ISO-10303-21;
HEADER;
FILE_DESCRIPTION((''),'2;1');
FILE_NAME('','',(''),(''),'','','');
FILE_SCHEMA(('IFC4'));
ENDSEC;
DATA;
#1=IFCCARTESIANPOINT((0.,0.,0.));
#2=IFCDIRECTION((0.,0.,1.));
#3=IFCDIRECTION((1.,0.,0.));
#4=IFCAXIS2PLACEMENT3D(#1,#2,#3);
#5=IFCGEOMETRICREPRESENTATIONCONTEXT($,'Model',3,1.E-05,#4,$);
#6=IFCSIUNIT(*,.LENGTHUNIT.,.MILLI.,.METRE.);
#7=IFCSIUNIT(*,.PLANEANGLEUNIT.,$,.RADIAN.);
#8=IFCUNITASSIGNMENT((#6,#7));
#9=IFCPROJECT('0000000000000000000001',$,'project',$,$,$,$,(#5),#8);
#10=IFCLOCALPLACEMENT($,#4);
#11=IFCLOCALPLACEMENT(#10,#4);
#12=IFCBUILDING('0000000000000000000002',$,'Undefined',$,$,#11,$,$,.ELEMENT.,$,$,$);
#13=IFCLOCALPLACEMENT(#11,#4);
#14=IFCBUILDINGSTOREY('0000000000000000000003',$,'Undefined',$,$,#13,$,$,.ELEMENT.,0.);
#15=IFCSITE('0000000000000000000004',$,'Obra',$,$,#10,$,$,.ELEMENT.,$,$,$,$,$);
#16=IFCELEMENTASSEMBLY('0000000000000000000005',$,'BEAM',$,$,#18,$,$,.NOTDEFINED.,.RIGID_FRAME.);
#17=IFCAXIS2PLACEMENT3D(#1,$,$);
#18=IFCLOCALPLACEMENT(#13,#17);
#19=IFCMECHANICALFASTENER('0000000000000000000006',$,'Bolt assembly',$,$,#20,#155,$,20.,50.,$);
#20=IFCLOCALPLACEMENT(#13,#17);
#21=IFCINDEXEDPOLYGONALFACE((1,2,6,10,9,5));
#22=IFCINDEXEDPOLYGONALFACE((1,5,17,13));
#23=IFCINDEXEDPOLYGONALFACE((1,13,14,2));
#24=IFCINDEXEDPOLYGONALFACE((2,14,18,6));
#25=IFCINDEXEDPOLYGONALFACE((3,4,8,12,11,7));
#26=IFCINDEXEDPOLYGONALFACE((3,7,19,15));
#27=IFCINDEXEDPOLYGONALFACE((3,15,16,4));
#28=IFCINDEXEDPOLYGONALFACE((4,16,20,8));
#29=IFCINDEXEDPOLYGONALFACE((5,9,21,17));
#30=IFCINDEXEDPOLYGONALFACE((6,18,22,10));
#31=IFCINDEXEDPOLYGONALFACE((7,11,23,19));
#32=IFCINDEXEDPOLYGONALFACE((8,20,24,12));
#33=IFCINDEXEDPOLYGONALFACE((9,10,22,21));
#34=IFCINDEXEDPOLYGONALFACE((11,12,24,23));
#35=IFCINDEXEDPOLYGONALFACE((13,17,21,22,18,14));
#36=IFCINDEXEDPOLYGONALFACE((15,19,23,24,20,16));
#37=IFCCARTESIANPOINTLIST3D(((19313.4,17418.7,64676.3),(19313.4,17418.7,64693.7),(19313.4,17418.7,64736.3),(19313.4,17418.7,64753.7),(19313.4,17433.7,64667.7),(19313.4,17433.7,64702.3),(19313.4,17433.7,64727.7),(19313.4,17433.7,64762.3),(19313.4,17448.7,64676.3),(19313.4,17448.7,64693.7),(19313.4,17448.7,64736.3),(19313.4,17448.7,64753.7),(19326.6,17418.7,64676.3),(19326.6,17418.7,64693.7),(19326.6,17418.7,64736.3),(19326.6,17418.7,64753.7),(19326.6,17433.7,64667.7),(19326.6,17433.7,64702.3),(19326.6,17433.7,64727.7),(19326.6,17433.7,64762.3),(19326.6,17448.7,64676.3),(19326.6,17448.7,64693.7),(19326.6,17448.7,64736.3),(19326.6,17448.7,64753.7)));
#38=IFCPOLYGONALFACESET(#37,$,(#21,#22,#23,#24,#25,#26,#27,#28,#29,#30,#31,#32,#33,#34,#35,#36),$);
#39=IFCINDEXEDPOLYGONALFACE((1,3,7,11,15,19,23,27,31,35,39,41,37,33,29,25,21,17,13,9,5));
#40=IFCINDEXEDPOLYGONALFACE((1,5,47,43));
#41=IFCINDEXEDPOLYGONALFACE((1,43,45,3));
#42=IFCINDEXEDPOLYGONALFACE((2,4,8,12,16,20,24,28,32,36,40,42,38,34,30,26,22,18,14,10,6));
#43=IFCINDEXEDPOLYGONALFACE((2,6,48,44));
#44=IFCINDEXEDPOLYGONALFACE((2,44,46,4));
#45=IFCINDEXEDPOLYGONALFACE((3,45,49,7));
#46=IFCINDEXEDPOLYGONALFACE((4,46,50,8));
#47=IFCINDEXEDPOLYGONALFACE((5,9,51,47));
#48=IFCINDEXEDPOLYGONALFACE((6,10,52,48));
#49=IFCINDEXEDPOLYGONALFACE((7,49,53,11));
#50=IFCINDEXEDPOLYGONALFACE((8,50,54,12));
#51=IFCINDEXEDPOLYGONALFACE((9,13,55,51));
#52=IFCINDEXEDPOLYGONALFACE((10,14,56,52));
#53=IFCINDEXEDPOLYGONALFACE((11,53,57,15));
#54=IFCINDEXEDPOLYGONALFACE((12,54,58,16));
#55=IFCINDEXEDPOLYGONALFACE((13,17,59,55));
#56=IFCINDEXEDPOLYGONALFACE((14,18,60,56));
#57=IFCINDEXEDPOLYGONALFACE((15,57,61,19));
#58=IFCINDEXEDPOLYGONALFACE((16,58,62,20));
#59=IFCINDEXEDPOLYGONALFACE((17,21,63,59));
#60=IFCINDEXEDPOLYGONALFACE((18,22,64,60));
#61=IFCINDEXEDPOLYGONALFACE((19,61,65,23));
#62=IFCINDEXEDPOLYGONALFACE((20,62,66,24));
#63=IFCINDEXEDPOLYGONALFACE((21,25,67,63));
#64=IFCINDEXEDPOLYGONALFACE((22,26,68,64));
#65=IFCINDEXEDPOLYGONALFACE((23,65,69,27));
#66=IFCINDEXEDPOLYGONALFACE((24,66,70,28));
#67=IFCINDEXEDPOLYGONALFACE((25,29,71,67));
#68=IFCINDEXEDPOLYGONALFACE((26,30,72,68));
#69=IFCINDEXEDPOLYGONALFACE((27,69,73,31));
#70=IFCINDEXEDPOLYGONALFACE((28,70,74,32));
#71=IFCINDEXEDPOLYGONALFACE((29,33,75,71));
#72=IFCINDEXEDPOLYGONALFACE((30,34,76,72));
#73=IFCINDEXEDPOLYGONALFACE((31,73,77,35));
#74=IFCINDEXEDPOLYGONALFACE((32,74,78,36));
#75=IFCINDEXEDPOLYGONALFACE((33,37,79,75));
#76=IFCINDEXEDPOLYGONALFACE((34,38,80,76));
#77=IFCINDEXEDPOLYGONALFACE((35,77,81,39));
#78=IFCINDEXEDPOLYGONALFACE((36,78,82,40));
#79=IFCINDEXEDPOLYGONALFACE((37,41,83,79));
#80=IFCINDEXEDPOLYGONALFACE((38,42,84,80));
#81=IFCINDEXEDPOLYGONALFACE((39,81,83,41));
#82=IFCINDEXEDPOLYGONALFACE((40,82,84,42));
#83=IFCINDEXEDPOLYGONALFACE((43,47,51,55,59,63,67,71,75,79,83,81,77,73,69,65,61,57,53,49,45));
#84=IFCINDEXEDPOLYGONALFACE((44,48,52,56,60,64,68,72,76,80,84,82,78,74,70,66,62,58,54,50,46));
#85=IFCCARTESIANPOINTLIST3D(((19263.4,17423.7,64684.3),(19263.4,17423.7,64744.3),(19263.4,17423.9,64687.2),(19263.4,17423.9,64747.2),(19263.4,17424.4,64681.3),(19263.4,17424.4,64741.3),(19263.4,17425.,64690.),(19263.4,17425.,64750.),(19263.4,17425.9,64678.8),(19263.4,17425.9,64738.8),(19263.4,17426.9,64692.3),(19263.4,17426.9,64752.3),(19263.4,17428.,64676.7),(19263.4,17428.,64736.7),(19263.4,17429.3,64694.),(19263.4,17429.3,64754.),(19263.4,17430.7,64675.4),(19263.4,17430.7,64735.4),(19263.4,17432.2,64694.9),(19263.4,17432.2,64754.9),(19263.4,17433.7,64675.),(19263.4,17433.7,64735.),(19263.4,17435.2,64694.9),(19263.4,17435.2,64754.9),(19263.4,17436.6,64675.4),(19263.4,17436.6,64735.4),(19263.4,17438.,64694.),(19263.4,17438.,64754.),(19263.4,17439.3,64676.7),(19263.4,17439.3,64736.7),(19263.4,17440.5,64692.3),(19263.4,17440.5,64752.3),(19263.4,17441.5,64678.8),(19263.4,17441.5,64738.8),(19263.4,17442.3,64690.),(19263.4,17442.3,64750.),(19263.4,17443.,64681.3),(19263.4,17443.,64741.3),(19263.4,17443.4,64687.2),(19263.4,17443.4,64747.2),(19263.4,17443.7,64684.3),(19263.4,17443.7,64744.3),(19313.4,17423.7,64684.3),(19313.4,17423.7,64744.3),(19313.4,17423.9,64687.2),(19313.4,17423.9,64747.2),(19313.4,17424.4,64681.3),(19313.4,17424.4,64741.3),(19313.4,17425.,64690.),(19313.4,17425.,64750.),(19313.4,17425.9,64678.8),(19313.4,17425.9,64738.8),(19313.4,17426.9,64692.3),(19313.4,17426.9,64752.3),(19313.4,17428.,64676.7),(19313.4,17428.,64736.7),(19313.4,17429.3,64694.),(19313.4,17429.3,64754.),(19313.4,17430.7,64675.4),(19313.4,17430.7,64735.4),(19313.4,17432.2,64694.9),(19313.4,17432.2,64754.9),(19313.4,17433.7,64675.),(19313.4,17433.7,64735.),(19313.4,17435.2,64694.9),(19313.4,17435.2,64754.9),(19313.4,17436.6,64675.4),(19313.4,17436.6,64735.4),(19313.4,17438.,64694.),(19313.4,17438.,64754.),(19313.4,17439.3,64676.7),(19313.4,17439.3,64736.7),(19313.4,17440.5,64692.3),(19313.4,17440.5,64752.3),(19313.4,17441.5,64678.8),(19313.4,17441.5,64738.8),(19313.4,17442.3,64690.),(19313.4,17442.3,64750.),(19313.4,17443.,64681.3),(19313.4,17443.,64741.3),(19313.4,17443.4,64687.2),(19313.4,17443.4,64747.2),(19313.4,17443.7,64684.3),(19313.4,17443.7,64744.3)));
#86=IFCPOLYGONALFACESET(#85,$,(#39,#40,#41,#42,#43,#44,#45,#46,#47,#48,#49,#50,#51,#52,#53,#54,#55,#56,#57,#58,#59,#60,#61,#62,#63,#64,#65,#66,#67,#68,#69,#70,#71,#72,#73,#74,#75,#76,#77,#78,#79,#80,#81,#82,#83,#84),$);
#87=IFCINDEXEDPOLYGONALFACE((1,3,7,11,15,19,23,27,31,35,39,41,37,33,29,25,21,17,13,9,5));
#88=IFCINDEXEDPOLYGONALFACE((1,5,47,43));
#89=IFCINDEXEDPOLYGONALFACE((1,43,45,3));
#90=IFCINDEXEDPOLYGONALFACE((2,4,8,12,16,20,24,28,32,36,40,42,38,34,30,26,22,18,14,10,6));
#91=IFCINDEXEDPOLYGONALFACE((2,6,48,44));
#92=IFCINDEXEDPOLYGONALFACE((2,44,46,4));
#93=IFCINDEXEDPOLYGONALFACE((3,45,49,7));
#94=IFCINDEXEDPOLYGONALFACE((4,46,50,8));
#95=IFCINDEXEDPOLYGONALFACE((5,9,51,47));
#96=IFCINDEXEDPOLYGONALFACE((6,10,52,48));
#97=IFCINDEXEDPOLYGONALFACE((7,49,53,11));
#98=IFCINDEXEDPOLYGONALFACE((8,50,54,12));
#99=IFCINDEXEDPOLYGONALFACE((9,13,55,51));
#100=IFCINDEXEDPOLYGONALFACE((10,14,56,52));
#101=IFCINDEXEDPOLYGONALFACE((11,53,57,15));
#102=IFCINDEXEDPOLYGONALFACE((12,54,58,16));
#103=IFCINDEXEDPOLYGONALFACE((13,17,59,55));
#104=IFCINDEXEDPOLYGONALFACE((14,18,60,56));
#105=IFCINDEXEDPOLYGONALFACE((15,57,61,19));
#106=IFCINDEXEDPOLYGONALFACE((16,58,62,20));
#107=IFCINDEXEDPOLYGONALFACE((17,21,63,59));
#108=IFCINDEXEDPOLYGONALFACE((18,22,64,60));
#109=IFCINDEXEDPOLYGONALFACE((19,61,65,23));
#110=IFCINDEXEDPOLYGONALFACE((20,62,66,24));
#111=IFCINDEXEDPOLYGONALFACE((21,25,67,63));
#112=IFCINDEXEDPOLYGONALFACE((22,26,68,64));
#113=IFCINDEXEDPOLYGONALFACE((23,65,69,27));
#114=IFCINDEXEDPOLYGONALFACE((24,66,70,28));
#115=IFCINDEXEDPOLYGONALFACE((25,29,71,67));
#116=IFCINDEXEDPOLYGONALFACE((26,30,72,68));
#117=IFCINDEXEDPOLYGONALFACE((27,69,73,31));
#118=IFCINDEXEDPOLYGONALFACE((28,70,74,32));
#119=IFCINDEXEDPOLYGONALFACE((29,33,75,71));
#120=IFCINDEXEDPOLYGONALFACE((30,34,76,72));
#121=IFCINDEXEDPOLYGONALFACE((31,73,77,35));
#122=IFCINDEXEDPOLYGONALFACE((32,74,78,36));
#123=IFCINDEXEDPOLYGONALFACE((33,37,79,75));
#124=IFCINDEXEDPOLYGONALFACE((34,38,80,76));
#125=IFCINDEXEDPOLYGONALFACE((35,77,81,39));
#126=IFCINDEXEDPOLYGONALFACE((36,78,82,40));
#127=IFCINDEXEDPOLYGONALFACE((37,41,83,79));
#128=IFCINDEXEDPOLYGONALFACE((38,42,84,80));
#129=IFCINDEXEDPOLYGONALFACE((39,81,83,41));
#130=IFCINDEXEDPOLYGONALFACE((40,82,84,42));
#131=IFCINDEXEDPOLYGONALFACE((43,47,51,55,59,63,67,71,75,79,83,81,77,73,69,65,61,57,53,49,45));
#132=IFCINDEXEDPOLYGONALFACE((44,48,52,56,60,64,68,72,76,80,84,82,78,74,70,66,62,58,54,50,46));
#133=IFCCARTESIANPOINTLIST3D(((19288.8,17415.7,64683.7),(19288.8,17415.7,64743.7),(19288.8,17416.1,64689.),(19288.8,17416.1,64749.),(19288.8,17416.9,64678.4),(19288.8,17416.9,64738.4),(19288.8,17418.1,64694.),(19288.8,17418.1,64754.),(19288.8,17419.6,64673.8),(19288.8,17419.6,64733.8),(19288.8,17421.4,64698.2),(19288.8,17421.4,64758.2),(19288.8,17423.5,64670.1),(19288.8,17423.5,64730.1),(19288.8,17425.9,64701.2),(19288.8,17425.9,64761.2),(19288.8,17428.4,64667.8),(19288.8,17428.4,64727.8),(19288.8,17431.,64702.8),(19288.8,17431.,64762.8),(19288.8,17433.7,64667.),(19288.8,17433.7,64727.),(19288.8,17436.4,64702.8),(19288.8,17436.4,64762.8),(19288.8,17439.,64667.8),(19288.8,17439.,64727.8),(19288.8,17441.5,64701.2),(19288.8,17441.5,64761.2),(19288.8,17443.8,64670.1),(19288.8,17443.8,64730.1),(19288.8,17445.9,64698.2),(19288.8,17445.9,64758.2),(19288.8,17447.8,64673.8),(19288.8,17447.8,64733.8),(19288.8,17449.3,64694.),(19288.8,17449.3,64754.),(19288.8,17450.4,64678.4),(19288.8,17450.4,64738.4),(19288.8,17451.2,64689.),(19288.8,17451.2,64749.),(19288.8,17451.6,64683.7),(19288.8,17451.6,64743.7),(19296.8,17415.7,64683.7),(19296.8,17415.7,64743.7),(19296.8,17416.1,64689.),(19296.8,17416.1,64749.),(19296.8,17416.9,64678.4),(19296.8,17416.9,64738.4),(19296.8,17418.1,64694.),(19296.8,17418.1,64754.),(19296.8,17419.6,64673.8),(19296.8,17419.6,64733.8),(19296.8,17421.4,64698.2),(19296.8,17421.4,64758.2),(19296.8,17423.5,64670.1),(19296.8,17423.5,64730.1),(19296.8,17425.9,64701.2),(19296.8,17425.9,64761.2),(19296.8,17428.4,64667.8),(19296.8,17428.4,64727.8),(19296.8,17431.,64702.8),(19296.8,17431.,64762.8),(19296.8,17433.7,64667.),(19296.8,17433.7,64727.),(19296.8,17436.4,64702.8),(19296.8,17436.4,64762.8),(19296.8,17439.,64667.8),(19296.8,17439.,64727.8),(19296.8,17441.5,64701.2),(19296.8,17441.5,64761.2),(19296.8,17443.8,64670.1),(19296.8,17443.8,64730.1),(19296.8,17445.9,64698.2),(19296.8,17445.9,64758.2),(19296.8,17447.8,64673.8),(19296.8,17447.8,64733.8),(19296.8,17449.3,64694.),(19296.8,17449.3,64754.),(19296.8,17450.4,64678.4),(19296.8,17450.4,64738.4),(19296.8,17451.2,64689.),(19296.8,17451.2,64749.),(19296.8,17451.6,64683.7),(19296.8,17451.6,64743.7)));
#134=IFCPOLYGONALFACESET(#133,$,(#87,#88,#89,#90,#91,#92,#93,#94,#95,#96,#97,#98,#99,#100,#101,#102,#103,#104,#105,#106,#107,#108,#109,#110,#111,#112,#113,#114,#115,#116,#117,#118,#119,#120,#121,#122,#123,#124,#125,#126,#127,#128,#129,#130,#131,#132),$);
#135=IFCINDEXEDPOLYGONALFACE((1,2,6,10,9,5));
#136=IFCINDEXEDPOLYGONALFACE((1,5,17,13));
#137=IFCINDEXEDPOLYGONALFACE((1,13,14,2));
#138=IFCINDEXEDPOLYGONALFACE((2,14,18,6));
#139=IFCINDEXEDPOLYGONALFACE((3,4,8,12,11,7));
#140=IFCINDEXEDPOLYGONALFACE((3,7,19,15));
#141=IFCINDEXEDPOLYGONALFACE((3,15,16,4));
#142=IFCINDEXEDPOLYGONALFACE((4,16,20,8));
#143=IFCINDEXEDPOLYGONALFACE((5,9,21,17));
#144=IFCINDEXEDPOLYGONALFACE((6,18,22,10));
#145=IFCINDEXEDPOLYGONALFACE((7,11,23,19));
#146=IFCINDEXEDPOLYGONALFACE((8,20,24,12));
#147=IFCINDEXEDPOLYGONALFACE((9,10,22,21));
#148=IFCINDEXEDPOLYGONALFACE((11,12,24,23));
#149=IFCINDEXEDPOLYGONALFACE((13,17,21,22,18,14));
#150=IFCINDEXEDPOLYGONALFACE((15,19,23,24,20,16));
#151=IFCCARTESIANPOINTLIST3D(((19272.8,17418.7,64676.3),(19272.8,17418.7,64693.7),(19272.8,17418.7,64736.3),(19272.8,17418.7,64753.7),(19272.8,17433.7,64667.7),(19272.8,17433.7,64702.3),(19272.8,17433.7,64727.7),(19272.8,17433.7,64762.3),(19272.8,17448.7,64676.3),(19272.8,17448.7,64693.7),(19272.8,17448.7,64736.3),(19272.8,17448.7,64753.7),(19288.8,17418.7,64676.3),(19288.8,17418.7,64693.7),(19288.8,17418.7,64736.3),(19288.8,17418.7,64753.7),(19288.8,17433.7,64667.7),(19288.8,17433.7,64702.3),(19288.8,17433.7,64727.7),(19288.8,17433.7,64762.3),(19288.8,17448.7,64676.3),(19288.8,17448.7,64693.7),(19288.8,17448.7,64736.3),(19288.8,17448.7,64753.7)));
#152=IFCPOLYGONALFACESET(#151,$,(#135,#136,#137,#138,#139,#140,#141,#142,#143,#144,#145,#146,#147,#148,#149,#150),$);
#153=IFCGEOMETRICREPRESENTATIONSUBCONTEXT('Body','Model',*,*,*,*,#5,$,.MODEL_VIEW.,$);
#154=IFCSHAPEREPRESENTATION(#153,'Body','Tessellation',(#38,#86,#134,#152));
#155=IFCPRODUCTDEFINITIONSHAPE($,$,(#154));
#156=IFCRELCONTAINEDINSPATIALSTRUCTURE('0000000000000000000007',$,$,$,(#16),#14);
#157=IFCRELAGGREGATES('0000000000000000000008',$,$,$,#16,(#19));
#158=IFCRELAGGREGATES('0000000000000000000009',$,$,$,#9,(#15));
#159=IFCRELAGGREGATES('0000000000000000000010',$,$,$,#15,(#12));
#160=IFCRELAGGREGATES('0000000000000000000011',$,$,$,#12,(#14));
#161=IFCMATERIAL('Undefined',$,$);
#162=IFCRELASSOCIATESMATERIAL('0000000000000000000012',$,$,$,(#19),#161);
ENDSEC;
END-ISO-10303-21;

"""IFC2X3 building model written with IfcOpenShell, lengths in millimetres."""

from ifc_helpers import new_model, si_unit, frame, origin_with_axes, origin_2d_with_axis, place, context, subcontext, project, spatial, polyline, circle, outline, extrude, source, transform, mapped, material, element, aggregate, save


model = new_model("IFC2X3")

# Units and contexts
model_context = context("Model", 3, precision=1e-05, world=origin_with_axes())
body_context = subcontext(model_context, "Body", "Model", "MODEL_VIEW")
ifc_project = project(units=[si_unit("LENGTHUNIT", "METRE", prefix="MILLI"), si_unit("PLANEANGLEUNIT", "RADIAN")], contexts=[model_context])

# Site, building, storey
site_placement = place(None, origin_with_axes())
site = spatial("IfcSite", under=ifc_project, at=site_placement, Name="Obra", CompositionType="ELEMENT")
building_placement = place(site_placement, origin_with_axes())
building = spatial("IfcBuilding", under=site, at=building_placement, Name="Undefined", CompositionType="ELEMENT")
storey_placement = place(building_placement, origin_with_axes())
storey = spatial("IfcBuildingStorey", under=building, at=storey_placement, Name="Undefined", CompositionType="ELEMENT", Elevation=0.0)

# Shared definitions
ifc_material = material(Name="Undefined")
shared_shape_1 = source(origin_with_axes(), body_context, "Body", "SweptSolid", [
    extrude(outline(polyline([(17.3, 0.0), (8.7, 15.0), (-8.7, 15.0), (-17.3, 0.0), (-8.7, -15.0), (8.7, -15.0), (17.3, 0.0)])), frame((0.0, -26.5, 0.0), z_axis=(0.0, 1.0, 0.0), x_axis=(1.0, 0.0, 0.0)), (0.0, 0.0, 1.0), 13.2),
    extrude(circle(Radius=10.0, at=origin_2d_with_axis()), frame((0.0, -13.3, 0.0), z_axis=(0.0, 1.0, 0.0), x_axis=(1.0, 0.0, 0.0)), (0.0, 0.0, 1.0), 50.0),
    extrude(circle(Radius=18.0, at=origin_2d_with_axis()), frame((0.0, 3.3, 0.0), z_axis=(0.0, 1.0, 0.0), x_axis=(1.0, 0.0, 0.0)), (0.0, 0.0, 1.0), 8.0),
    extrude(outline(polyline([(17.3, 0.0), (8.7, 15.0), (-8.7, 15.0), (-17.3, 0.0), (-8.7, -15.0), (8.7, -15.0), (17.3, 0.0)])), frame((0.0, 11.3, 0.0), z_axis=(0.0, 1.0, 0.0), x_axis=(1.0, 0.0, 0.0)), (0.0, 0.0, 1.0), 16.0),
])

# Element assembly, mechanical fastener
assembly_1_placement = place(storey_placement, origin_with_axes())
assembly_1 = element("IfcElementAssembly", 1, at=assembly_1_placement, inside=storey, Name="BEAM", AssemblyPlace="NOTDEFINED", PredefinedType="RIGID_FRAME")
mechanical_fastener_1_placement = place(assembly_1_placement, frame((19300.1, 17393.7, 64850.0), z_axis=(0.0, 1.0, 0.0), x_axis=(0.0, 0.0, -1.0)))
mechanical_fastener_1 = element("IfcMechanicalFastener", 2, at=mechanical_fastener_1_placement, material=ifc_material, Name="Bolt assembly", NominalDiameter=20.0, NominalLength=50.0, context=body_context, shape_type="MappedRepresentation", body=[
    mapped(shared_shape_1, transform((105.0, 0.0, 40.0))),
    mapped(shared_shape_1, transform((165.0, 0.0, 40.0))),
])

aggregate(assembly_1, [mechanical_fastener_1])

save(model, "model.ifc")
